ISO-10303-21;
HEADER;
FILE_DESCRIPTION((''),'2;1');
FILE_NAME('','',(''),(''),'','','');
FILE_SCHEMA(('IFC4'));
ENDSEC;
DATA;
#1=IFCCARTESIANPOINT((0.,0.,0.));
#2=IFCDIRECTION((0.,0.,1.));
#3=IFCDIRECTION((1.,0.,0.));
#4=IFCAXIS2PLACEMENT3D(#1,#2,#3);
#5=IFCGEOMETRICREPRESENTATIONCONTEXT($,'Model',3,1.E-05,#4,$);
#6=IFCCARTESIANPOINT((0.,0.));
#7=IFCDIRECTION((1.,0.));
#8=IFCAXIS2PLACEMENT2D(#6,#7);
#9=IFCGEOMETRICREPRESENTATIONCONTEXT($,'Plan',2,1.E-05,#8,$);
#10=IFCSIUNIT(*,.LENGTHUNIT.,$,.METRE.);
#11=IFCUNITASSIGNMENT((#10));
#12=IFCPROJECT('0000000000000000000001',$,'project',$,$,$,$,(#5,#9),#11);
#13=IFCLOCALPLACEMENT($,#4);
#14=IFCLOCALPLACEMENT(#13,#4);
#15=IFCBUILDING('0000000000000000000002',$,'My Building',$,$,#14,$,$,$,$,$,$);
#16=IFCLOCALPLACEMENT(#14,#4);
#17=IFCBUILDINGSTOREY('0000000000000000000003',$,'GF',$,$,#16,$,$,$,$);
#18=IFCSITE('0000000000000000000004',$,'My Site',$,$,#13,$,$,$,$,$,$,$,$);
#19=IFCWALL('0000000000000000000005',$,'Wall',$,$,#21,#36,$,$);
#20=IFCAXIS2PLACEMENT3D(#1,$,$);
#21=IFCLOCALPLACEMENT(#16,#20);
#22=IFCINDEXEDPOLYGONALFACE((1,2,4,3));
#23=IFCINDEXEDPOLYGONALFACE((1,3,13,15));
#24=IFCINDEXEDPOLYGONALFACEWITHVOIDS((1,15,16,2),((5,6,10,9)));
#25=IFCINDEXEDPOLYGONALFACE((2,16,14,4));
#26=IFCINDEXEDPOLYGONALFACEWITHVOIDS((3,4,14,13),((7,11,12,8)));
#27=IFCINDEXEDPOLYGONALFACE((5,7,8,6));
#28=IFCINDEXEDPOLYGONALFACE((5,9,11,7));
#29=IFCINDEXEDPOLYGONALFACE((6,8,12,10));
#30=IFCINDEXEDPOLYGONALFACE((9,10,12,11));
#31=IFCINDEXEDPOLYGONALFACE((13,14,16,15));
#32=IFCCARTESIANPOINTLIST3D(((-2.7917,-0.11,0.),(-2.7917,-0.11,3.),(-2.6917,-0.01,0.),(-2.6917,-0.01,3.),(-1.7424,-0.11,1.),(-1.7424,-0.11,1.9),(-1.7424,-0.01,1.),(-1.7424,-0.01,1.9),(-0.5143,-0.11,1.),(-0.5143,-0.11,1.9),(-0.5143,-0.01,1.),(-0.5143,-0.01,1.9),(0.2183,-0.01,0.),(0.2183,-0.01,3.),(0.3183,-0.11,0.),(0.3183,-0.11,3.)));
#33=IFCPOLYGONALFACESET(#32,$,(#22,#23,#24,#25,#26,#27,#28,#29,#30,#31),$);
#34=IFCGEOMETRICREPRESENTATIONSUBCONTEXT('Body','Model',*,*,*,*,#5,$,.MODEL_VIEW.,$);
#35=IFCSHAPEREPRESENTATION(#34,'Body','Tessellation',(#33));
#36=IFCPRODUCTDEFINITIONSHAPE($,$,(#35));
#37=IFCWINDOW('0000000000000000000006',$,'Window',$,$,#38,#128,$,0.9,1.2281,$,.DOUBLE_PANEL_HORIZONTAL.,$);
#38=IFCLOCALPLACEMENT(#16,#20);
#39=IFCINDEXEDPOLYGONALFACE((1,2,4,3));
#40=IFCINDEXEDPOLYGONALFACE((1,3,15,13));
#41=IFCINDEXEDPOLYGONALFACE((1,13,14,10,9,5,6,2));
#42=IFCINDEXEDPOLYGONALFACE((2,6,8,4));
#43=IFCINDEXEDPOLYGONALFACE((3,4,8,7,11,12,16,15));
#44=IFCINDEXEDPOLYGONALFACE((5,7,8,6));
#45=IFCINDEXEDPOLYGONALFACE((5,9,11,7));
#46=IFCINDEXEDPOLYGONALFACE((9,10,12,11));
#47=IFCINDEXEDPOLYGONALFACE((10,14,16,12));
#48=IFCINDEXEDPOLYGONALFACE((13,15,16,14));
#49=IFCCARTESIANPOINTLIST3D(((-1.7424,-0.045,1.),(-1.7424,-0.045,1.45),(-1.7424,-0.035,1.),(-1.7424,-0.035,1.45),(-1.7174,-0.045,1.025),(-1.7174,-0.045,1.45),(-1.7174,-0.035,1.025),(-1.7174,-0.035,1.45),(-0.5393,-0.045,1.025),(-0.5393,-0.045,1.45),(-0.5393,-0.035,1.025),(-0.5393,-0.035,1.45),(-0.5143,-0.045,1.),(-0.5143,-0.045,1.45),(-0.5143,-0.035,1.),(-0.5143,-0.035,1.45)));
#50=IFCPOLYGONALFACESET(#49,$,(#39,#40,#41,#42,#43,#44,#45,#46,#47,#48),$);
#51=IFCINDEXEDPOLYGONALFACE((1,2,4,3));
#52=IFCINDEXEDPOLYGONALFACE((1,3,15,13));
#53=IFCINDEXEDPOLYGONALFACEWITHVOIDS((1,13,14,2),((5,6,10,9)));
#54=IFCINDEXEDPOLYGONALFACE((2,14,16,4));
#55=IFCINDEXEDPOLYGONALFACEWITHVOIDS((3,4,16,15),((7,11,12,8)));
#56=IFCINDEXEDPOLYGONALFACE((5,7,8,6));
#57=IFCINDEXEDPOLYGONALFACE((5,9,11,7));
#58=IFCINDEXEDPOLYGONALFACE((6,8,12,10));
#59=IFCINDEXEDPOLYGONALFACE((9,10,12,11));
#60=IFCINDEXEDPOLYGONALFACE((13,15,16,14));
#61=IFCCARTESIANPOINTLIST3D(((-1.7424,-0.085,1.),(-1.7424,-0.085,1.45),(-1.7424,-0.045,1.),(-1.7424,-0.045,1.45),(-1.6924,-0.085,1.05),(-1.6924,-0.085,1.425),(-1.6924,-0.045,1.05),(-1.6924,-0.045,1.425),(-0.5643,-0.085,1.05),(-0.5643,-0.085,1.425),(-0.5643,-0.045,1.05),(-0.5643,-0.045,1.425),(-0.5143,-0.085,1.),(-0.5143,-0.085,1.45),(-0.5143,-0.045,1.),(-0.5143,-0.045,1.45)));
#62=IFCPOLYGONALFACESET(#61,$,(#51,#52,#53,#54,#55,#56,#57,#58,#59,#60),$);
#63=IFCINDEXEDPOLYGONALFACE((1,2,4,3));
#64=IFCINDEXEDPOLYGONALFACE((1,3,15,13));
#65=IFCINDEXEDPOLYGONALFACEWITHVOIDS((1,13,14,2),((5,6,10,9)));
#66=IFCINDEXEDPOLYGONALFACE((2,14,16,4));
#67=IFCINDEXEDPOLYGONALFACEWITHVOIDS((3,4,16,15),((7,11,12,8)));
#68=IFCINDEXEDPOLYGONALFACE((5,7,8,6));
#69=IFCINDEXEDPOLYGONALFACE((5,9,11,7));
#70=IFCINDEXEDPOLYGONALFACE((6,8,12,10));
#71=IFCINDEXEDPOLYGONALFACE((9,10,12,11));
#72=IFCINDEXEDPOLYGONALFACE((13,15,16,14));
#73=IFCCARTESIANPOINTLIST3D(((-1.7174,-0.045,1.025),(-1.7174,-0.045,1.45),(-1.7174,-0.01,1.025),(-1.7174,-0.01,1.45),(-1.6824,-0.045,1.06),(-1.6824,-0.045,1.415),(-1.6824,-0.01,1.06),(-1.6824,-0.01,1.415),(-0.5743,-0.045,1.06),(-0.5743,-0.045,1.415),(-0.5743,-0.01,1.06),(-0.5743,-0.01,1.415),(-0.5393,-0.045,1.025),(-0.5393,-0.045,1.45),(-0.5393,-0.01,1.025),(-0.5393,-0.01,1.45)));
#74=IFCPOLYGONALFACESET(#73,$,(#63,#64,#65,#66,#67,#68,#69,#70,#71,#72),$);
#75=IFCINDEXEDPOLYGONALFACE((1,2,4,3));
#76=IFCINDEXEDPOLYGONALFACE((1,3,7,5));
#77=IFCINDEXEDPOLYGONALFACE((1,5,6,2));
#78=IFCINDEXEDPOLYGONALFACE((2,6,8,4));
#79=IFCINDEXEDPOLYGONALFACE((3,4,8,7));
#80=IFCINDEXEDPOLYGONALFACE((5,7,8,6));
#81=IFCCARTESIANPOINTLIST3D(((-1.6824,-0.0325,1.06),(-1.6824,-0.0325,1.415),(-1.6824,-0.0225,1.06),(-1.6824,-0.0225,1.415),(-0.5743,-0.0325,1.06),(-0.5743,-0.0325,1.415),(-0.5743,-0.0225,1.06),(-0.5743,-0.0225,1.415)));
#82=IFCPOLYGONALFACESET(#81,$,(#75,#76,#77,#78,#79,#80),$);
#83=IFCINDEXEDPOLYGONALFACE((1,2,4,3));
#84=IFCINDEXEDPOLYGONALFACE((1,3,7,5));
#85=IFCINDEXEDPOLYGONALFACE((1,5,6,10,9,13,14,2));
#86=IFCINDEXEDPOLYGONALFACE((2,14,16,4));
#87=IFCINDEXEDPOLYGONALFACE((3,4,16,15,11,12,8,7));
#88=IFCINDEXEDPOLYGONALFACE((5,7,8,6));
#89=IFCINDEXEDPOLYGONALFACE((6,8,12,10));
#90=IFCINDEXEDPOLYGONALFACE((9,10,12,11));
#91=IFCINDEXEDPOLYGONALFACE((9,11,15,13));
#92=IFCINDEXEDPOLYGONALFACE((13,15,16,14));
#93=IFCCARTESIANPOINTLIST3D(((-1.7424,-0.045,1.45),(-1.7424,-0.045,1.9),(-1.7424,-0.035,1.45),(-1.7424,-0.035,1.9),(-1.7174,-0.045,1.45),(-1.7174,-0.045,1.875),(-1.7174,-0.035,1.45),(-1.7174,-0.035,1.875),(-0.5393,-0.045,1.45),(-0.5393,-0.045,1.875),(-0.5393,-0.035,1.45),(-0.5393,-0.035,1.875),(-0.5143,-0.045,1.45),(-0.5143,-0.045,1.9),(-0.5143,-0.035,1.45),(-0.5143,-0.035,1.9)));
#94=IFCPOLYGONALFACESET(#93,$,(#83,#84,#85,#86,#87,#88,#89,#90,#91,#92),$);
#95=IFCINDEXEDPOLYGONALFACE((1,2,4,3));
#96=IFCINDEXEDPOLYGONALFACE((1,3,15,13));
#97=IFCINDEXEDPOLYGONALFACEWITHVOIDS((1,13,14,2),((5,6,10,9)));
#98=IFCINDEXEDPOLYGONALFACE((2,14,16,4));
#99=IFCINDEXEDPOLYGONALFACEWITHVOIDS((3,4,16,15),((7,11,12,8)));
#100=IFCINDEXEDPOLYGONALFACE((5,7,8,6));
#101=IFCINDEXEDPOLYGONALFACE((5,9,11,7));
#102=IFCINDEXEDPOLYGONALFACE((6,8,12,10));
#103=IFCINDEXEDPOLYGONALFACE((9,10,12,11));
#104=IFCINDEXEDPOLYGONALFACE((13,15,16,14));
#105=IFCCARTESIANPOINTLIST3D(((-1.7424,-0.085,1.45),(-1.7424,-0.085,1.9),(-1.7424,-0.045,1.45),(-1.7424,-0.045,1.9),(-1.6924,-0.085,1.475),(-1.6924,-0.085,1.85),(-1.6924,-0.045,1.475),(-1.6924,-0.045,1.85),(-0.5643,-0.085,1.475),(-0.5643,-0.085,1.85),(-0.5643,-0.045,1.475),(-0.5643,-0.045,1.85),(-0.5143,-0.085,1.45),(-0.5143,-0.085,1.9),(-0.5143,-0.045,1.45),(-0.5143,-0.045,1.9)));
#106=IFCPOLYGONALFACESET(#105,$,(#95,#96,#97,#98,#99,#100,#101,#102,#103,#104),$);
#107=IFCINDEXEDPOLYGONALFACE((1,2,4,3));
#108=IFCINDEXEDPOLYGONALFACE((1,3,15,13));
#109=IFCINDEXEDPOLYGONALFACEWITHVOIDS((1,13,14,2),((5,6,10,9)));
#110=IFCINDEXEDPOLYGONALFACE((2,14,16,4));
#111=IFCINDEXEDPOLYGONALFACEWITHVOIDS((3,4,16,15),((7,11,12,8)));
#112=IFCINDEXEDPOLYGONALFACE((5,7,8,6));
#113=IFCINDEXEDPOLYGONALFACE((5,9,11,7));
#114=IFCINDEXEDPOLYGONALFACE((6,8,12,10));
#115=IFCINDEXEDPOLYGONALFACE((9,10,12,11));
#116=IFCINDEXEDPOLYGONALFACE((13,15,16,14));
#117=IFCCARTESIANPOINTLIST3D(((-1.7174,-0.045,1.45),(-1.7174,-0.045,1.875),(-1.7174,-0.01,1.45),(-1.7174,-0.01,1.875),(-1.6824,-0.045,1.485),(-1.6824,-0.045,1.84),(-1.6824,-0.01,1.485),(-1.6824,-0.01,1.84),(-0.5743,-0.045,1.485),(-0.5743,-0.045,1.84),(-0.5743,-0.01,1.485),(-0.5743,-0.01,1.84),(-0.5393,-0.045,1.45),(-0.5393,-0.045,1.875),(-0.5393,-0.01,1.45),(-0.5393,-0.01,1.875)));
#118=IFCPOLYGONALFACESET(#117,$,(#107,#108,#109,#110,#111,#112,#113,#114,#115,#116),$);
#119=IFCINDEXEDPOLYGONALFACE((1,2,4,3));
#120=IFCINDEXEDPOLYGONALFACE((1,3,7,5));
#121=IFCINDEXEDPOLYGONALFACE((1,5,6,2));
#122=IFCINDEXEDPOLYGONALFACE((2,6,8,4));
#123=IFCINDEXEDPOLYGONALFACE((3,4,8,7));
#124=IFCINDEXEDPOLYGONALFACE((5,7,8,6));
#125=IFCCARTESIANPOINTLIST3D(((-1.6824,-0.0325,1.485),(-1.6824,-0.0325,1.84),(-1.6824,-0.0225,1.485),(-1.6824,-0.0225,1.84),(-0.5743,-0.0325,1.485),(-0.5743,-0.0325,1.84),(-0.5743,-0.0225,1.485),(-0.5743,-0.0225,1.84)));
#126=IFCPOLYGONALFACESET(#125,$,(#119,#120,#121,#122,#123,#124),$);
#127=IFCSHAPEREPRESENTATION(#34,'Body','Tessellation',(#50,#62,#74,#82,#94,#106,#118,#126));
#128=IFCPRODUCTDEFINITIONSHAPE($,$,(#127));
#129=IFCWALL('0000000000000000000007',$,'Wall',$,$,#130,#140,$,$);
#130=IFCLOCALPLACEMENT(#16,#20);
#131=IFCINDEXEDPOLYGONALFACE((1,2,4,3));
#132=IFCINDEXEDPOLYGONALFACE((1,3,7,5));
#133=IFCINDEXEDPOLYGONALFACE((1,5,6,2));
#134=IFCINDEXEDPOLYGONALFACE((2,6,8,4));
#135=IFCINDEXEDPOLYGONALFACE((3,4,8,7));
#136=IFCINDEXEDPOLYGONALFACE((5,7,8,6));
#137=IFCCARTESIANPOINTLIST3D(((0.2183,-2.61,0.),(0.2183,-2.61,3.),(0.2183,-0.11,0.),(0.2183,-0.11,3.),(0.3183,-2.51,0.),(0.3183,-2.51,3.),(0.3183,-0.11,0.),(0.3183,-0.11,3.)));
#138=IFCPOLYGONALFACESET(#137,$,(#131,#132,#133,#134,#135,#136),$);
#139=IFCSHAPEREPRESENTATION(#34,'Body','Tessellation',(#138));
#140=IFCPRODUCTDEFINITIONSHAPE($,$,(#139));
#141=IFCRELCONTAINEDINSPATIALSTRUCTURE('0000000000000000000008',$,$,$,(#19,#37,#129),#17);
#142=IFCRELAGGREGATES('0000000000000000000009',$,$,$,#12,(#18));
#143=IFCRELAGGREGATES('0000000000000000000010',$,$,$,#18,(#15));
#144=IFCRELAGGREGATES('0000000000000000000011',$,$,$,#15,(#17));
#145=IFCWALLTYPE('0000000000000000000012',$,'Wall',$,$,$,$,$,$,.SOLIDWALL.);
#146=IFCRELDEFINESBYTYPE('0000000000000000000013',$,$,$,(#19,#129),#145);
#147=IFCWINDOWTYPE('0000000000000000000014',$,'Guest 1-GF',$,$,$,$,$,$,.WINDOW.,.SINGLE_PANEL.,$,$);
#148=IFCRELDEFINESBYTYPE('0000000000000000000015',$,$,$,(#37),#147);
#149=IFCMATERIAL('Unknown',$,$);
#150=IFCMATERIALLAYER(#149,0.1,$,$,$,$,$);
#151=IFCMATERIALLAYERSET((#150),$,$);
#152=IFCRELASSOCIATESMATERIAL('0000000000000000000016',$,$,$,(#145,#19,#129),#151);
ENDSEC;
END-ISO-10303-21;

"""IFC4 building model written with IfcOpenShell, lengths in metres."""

from ifc_helpers import new_model, entity, si_unit, frame, origin_with_axes, origin_2d_with_axis, place, context, subcontext, project, spatial, line, indexed_curve, outline, extrude, shape, source, transform, mapped, material, layer, layer_set, layer_usage, type_object, type_shapes, element, fill, save


model = new_model("IFC4")

# Units and contexts
model_context = context("Model", 3, precision=1e-05, world=origin_with_axes())
plan_context = context("Plan", 2, precision=1e-05, world=origin_2d_with_axis())
body_context_1 = subcontext(model_context, "Body", "Model", "MODEL_VIEW")
body_context_2 = subcontext(plan_context, "Body", "Plan", "PLAN_VIEW")
ifc_project = project(units=[si_unit("LENGTHUNIT", "METRE")], contexts=[model_context, plan_context])

# Site, building, storey
site_placement = place(None, origin_with_axes())
site = spatial("IfcSite", under=ifc_project, at=site_placement, Name="My Site")
building_placement = place(site_placement, origin_with_axes())
building = spatial("IfcBuilding", under=site, at=building_placement, Name="My Building")
storey_placement = place(building_placement, origin_with_axes())
storey = spatial("IfcBuildingStorey", under=building, at=storey_placement, Name="GF")

# Shared definitions
ifc_material = material(Name="Unknown")

# Shared definitions
ifc_layer_1 = layer(ifc_material, 0.1)
ifc_layer_set_1 = layer_set([ifc_layer_1])
wall_type = type_object("IfcWallType", Name="Wall", PredefinedType="SOLIDWALL", material=ifc_layer_set_1)

# Wall, opening, window
ifc_layer_usage_1 = layer_usage(ifc_layer_set_1, "AXIS2", "POSITIVE", 0.0)
wall_1_placement = place(storey_placement, frame((-2.7917, -0.11, 0.0), z_axis=(0.0, 0.0, 1.0), x_axis=(1.0, 0.0, 0.0)))
wall_1 = element("IfcWall", 1, at=wall_1_placement, inside=storey, type_object=wall_type, material=ifc_layer_usage_1, Name="Wall", context=body_context_1, shape_type="SweptSolid", body=[
    extrude(outline(indexed_curve([(0.0, 0.0), (0.1, 0.1), (3.01, 0.1), (3.11, 0.0)], segments=[line(1, 2, 3, 4, 1)])), origin_with_axes(), (0.0, 0.0, 1.0), 3.0),
])
shared_shape_1 = source(origin_with_axes(), body_context_1, "Body", "SweptSolid", [
    extrude(outline(indexed_curve([(0.0, 0.0), (1.2281, 0.0), (1.2281, 0.9), (0.0, 0.9)], segments=[line(1, 2, 3, 4, 1)])), frame((0.0, -0.6, 0.0), z_axis=(0.0, -1.0, 0.0), x_axis=(1.0, 0.0, 0.0)), (0.0, 0.0, -1.0), 1.2),
])
opening_1_placement = place(wall_1_placement, frame((1.0493, -0.025, 1.0), z_axis=(0.0, 0.0, 1.0), x_axis=(1.0, 0.0, 0.0)))
opening_1 = element("IfcOpeningElement", 2, at=opening_1_placement, cuts=wall_1, PredefinedType="OPENING", context=body_context_1, shape_type="MappedRepresentation", body=[
    mapped(shared_shape_1, transform((0.0, 0.0, 0.0), x_axis=(1.0, 0.0, 0.0), y_axis=(0.0, 1.0, 0.0), z_axis=(0.0, 0.0, 1.0), scale=1.0)),
])
window_type_1 = type_object("IfcWindowType", Name="Guest 1-GF", PartitioningType="SINGLE_PANEL", PredefinedType="WINDOW")
shared_shape_2 = source(origin_with_axes(), body_context_1, "Body", "SweptSolid", [
    extrude(outline(indexed_curve([(1.2281, 0.45), (1.2281, 0.0), (0.0, 0.0), (0.0, 0.45), (0.025, 0.45), (0.025, 0.025), (1.2031, 0.025), (1.2031, 0.45)], segments=[line(1, 2, 3, 4, 5, 6, 7, 8, 1)])), frame((0.0, 0.09, 0.0), z_axis=(0.0, -1.0, 0.0), x_axis=(1.0, 0.0, 0.0)), (0.0, 0.0, -1.0), 0.01),
    extrude(outline(indexed_curve([(0.0, 0.0), (1.2281, 0.0), (1.2281, 0.45), (0.0, 0.45)], segments=[line(1, 2, 3, 4, 1)]), holes=[indexed_curve([(0.05, 0.05), (1.1781, 0.05), (1.1781, 0.425), (0.05, 0.425)], segments=[line(1, 2, 3, 4, 1)])]), frame((0.0, 0.05, 0.0), z_axis=(0.0, -1.0, 0.0), x_axis=(1.0, 0.0, 0.0)), (0.0, 0.0, -1.0), 0.04),
    extrude(outline(indexed_curve([(0.0, 0.0), (1.1781, 0.0), (1.1781, 0.425), (0.0, 0.425)], segments=[line(1, 2, 3, 4, 1)]), holes=[indexed_curve([(0.035, 0.035), (1.1431, 0.035), (1.1431, 0.39), (0.035, 0.39)], segments=[line(1, 2, 3, 4, 1)])]), frame((0.025, 0.09, 0.025), z_axis=(0.0, -1.0, 0.0), x_axis=(1.0, 0.0, 0.0)), (0.0, 0.0, -1.0), 0.035),
    extrude(outline(indexed_curve([(0.035, 0.035), (1.1431, 0.035), (1.1431, 0.39), (0.035, 0.39)], segments=[line(1, 2, 3, 4, 1)])), frame((0.025, 0.1025, 0.025), z_axis=(0.0, -1.0, 0.0), x_axis=(1.0, 0.0, 0.0)), (0.0, 0.0, -1.0), 0.01),
    extrude(outline(indexed_curve([(0.0, 0.0), (0.0, 0.45), (1.2281, 0.45), (1.2281, 0.0), (1.2031, 0.0), (1.2031, 0.425), (0.025, 0.425), (0.025, 0.0)], segments=[line(1, 2, 3, 4, 5, 6, 7, 8, 1)])), frame((0.0, 0.09, 0.45), z_axis=(0.0, -1.0, 0.0), x_axis=(1.0, 0.0, 0.0)), (0.0, 0.0, -1.0), 0.01),
    extrude(outline(indexed_curve([(0.0, 0.0), (1.2281, 0.0), (1.2281, 0.45), (0.0, 0.45)], segments=[line(1, 2, 3, 4, 1)]), holes=[indexed_curve([(0.05, 0.025), (1.1781, 0.025), (1.1781, 0.4), (0.05, 0.4)], segments=[line(1, 2, 3, 4, 1)])]), frame((0.0, 0.05, 0.45), z_axis=(0.0, -1.0, 0.0), x_axis=(1.0, 0.0, 0.0)), (0.0, 0.0, -1.0), 0.04),
    extrude(outline(indexed_curve([(0.0, 0.0), (1.1781, 0.0), (1.1781, 0.425), (0.0, 0.425)], segments=[line(1, 2, 3, 4, 1)]), holes=[indexed_curve([(0.035, 0.035), (1.1431, 0.035), (1.1431, 0.39), (0.035, 0.39)], segments=[line(1, 2, 3, 4, 1)])]), frame((0.025, 0.09, 0.45), z_axis=(0.0, -1.0, 0.0), x_axis=(1.0, 0.0, 0.0)), (0.0, 0.0, -1.0), 0.035),
    extrude(outline(indexed_curve([(0.035, 0.035), (1.1431, 0.035), (1.1431, 0.39), (0.035, 0.39)], segments=[line(1, 2, 3, 4, 1)])), frame((0.025, 0.1025, 0.45), z_axis=(0.0, -1.0, 0.0), x_axis=(1.0, 0.0, 0.0)), (0.0, 0.0, -1.0), 0.01),
])
shared_shape_3 = source(origin_with_axes(), body_context_2, "Body", "Curve2D", [
    entity("IfcIndexedPolyCurve", entity("IfcCartesianPointList2D", [[0.05, 0.05], [1.1781, 0.05]])),
    entity("IfcIndexedPolyCurve", entity("IfcCartesianPointList2D", [[0.0, 0.1], [0.025, 0.1], [0.025, 0.09], [0.05, 0.09], [0.05, 0.05], [0.0, 0.05]]), [entity("IfcLineIndex", [1, 2, 3, 4, 5, 6, 1])]),
    entity("IfcIndexedPolyCurve", entity("IfcCartesianPointList2D", [[1.2281, 0.1], [1.2031, 0.1], [1.2031, 0.09], [1.1781, 0.09], [1.1781, 0.05], [1.2281, 0.05]]), [entity("IfcLineIndex", [1, 2, 3, 4, 5, 6, 1])]),
    entity("IfcIndexedPolyCurve", entity("IfcCartesianPointList2D", [[0.025, 0.09], [0.06, 0.09], [0.06, 0.125], [0.025, 0.125]]), [entity("IfcLineIndex", [1, 2, 3, 4, 1])]),
    entity("IfcIndexedPolyCurve", entity("IfcCartesianPointList2D", [[1.2031, 0.09], [1.1681, 0.09], [1.1681, 0.125], [1.2031, 0.125]]), [entity("IfcLineIndex", [1, 2, 3, 4, 1])]),
    entity("IfcIndexedPolyCurve", entity("IfcCartesianPointList2D", [[0.06, 0.09], [1.1681, 0.09]])),
    entity("IfcIndexedPolyCurve", entity("IfcCartesianPointList2D", [[0.06, 0.125], [1.1681, 0.125]])),
    entity("IfcIndexedPolyCurve", entity("IfcCartesianPointList2D", [[0.06, 0.1075], [1.1681, 0.1075]])),
])
type_shapes(window_type_1, [shared_shape_2, shared_shape_3])
window_1_placement = place(opening_1_placement, origin_with_axes())
window_1 = element("IfcWindow", 3, at=window_1_placement, inside=storey, type_object=window_type_1, Name="Window", OverallHeight=0.9, OverallWidth=1.2281, PartitioningType="DOUBLE_PANEL_HORIZONTAL", shapes=[
    shape(body_context_1, "Body", "MappedRepresentation", [mapped(shared_shape_2, transform((0.0, 0.0, 0.0), x_axis=(1.0, 0.0, 0.0), y_axis=(0.0, 1.0, 0.0), z_axis=(0.0, 0.0, 1.0), scale=1.0))]),
    shape(body_context_2, "Body", "MappedRepresentation", [mapped(shared_shape_3, transform((0.0, 0.0, 0.0), x_axis=(1.0, 0.0, 0.0), y_axis=(0.0, 1.0, 0.0), z_axis=(0.0, 0.0, 1.0), scale=1.0))]),
])
fill(opening_1, window_1)

# Wall
ifc_layer_usage_2 = layer_usage(ifc_layer_set_1, "AXIS2", "POSITIVE", 0.0)
wall_2_placement = place(storey_placement, frame((0.2183, -0.11, 0.0), z_axis=(0.0, 0.0, 1.0), x_axis=(0.0, -1.0, 0.0)))
element("IfcWall", 4, at=wall_2_placement, inside=storey, type_object=wall_type, material=ifc_layer_usage_2, Name="Wall", context=body_context_1, shape_type="SweptSolid", body=[
    extrude(outline(indexed_curve([(0.0, 0.0), (0.0, 0.1), (2.4, 0.1), (2.5, 0.0)], segments=[line(1, 2, 3, 4, 1)])), origin_with_axes(), (0.0, 0.0, 1.0), 3.0),
])

save(model, "model.ifc")
